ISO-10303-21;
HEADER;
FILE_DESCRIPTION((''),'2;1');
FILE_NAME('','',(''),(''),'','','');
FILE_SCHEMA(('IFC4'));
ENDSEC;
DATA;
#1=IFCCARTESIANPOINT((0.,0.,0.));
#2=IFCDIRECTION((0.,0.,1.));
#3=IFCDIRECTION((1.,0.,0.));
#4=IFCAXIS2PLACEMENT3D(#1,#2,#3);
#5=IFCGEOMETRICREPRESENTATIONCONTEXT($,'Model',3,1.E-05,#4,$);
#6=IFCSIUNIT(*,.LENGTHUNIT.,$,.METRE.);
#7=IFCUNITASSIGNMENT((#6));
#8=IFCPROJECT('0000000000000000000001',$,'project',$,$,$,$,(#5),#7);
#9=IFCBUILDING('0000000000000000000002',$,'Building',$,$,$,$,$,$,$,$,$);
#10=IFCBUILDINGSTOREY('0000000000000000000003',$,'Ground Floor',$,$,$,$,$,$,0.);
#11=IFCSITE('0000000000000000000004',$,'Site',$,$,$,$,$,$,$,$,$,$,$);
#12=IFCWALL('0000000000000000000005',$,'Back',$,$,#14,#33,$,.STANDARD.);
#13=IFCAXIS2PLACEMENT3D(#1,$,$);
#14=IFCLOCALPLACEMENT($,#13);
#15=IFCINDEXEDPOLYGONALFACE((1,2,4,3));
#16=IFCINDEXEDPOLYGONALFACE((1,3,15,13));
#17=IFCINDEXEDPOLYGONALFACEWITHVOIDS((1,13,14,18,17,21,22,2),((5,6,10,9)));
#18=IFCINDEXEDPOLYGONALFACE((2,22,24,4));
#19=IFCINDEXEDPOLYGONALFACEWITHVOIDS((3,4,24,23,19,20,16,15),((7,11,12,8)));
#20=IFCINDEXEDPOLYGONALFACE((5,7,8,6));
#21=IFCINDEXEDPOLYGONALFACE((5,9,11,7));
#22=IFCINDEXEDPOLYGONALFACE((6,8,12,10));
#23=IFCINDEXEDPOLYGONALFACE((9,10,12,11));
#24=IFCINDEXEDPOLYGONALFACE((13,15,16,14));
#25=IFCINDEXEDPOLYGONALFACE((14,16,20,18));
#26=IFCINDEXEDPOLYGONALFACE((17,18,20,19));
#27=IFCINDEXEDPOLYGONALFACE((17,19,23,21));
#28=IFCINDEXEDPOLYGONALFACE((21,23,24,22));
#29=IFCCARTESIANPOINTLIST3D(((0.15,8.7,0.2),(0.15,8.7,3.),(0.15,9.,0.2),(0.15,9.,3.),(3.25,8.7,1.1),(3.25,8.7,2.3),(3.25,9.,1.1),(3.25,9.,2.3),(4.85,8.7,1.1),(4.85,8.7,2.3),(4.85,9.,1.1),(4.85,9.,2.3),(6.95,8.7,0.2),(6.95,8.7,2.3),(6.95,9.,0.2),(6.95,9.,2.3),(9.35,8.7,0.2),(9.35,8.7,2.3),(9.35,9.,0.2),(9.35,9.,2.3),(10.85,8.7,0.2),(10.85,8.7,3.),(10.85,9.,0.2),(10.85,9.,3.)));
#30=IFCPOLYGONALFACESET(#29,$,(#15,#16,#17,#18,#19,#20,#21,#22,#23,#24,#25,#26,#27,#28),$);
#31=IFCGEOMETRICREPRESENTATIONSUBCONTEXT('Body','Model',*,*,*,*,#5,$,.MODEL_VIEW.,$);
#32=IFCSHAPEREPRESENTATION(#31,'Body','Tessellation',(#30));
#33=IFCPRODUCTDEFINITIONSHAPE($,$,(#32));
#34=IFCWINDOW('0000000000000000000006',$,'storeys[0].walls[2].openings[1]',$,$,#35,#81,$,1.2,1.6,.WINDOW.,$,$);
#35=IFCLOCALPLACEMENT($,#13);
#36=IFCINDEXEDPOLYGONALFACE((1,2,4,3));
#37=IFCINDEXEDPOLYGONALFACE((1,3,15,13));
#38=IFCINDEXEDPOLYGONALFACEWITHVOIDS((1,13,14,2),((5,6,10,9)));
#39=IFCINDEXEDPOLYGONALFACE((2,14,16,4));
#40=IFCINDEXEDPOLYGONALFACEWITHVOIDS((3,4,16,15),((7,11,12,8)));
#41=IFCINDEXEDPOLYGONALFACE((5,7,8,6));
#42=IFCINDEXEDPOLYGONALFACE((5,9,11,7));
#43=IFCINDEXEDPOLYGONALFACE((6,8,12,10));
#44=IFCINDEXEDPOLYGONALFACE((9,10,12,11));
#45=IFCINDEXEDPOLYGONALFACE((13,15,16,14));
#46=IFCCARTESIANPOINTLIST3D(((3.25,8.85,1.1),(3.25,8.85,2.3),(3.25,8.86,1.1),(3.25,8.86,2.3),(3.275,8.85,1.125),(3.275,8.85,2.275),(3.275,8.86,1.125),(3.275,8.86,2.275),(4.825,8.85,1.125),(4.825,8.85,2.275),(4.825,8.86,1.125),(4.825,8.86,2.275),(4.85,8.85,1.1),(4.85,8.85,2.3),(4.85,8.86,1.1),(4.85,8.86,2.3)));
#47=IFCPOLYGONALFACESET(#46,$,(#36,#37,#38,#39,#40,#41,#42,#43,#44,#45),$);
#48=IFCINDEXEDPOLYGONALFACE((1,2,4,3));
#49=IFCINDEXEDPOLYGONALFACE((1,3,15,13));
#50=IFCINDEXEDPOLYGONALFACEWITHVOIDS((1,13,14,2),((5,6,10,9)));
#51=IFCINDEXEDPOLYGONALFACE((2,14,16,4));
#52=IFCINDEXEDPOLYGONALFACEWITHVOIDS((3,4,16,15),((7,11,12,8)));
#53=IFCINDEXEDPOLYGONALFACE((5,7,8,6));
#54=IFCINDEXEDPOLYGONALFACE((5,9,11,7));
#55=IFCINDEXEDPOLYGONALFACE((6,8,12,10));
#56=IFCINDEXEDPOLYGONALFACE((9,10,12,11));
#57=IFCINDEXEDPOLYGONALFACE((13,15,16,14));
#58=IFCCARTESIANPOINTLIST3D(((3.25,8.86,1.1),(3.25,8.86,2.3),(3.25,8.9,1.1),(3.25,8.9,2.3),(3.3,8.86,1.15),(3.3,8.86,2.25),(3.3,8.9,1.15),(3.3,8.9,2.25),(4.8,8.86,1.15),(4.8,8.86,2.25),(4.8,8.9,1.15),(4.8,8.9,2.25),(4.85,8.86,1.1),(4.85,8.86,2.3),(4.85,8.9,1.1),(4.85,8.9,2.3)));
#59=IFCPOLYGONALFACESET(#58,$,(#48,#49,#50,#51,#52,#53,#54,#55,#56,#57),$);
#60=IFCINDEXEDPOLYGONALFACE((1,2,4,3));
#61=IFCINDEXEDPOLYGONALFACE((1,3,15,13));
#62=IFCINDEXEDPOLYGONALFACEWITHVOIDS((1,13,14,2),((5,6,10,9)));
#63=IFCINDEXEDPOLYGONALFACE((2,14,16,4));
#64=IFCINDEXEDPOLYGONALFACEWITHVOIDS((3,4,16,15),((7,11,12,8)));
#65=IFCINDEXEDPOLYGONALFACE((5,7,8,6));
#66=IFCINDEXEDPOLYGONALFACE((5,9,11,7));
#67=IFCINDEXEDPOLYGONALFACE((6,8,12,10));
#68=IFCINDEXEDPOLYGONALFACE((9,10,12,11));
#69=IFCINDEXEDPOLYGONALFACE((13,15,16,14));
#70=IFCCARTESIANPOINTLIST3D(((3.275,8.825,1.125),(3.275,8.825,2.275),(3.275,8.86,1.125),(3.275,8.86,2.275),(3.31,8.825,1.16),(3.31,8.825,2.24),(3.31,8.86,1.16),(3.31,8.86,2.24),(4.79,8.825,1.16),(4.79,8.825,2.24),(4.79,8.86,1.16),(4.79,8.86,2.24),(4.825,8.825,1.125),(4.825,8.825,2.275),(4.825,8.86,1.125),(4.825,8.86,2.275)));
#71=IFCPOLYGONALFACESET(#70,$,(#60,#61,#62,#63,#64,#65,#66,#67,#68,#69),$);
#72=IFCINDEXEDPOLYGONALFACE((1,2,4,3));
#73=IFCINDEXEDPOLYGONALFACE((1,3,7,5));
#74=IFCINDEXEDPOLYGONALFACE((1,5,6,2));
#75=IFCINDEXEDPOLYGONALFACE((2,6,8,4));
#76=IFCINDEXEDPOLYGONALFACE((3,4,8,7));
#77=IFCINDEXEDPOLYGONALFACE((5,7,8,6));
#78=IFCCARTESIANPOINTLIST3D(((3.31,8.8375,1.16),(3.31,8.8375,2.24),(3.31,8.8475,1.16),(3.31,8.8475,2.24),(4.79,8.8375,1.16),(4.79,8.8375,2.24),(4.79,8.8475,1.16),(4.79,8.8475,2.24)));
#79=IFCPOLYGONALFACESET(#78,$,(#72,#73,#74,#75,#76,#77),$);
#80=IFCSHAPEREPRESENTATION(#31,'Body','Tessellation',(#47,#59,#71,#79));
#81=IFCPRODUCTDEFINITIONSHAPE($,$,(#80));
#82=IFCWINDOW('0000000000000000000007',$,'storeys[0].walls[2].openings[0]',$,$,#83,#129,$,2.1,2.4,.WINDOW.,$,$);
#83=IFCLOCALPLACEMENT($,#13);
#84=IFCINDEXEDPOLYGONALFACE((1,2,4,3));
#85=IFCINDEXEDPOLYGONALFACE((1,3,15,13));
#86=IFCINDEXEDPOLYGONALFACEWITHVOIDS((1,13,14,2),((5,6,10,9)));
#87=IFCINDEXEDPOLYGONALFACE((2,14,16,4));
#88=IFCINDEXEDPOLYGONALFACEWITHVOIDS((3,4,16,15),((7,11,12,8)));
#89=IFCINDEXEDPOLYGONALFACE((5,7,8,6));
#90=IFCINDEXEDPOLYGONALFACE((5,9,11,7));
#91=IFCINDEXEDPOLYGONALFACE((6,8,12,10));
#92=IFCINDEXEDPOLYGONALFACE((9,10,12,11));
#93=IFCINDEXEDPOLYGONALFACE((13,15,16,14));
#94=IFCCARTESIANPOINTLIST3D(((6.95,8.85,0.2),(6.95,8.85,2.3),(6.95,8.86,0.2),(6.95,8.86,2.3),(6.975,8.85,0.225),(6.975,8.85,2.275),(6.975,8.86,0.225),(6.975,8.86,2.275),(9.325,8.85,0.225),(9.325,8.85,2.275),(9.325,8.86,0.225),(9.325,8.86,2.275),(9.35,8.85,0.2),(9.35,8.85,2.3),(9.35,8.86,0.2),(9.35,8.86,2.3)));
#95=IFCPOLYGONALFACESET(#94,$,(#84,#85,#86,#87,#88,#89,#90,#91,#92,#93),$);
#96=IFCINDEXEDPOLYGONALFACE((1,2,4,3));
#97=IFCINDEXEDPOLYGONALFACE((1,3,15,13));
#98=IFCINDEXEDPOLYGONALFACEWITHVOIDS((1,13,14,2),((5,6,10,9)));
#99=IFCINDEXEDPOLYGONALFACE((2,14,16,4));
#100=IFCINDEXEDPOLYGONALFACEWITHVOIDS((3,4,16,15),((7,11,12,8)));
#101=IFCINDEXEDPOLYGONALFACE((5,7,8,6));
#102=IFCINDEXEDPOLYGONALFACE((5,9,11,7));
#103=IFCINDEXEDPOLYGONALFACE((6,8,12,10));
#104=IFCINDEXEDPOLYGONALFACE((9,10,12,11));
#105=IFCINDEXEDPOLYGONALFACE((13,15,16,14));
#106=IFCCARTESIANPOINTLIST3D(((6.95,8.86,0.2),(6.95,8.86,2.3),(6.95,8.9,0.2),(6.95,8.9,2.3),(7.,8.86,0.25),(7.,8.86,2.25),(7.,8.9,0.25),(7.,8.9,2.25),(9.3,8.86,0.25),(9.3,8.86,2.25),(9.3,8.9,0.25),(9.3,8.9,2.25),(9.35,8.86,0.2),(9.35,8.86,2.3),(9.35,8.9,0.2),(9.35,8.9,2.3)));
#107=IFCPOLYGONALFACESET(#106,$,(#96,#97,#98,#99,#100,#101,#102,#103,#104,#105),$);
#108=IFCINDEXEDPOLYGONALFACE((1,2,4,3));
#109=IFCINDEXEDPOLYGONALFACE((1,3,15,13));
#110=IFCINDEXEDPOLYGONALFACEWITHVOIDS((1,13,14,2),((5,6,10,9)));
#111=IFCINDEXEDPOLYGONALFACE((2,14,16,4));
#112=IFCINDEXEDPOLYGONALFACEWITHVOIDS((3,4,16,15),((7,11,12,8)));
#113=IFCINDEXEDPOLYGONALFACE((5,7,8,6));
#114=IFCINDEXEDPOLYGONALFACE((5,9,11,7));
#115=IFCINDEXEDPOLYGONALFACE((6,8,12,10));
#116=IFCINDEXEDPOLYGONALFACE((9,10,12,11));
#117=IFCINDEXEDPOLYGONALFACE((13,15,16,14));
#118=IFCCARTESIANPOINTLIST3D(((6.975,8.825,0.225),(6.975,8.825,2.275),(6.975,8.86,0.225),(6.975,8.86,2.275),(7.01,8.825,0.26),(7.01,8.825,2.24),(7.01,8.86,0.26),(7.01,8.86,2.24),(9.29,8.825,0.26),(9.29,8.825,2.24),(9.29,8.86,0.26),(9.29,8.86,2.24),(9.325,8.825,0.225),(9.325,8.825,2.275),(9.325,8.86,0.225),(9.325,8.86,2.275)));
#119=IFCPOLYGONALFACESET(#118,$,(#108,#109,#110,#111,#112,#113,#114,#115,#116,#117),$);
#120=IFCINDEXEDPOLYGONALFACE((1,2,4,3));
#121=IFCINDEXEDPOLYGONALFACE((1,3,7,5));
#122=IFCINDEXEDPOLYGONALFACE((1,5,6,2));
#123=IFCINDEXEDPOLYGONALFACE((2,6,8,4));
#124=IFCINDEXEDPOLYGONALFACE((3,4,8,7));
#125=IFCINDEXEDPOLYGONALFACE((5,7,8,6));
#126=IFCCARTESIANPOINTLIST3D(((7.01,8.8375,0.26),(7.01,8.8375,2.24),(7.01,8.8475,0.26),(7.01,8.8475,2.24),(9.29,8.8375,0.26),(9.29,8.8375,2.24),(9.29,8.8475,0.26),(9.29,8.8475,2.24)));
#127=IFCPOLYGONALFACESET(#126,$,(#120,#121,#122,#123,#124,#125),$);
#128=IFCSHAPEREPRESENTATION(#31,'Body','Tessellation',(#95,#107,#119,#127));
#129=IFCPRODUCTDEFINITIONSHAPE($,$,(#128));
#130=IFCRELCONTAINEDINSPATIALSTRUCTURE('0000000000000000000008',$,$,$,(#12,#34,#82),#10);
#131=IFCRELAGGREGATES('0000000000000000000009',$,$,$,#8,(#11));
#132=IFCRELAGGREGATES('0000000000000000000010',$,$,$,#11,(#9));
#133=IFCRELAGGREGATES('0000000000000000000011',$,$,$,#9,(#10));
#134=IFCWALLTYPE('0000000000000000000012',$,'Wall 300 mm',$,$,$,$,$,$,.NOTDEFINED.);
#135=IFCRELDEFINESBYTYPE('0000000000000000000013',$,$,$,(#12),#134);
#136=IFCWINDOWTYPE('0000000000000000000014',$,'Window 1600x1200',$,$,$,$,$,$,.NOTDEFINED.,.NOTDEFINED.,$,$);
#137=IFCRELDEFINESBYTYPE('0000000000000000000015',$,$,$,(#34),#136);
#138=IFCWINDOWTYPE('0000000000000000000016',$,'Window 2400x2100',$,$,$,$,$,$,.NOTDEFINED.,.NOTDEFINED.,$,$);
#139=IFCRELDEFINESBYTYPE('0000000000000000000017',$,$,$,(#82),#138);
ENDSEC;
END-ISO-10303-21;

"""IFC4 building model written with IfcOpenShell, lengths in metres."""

from ifc_helpers import new_model, si_unit, frame, origin_with_axes, place, context, subcontext, project, spatial, line, indexed_curve, outline, extrude, type_object, element, fill, save


model = new_model("IFC4")

# Units and contexts
model_context = context("Model", 3, precision=1e-05, world=origin_with_axes())
body_context = subcontext(model_context, "Body", "Model", "MODEL_VIEW")
ifc_project = project(units=[si_unit("LENGTHUNIT", "METRE")], contexts=[model_context])

# Site, building, storey
site = spatial("IfcSite", under=ifc_project, Name="Site")
building = spatial("IfcBuilding", under=site, Name="Building")
storey = spatial("IfcBuildingStorey", under=building, Name="Ground Floor", Elevation=0.0)

# Shared definitions
wall_type_1 = type_object("IfcWallType", Name="Wall 300 mm", PredefinedType="NOTDEFINED")
window_type_1 = type_object("IfcWindowType", Name="Window 1600x1200", PartitioningType="NOTDEFINED", PredefinedType="NOTDEFINED")

# Wall, openings, windows
wall_1_placement = place(None, frame((10.85, 8.85, 0.2), z_axis=(0.0, 0.0, 1.0), x_axis=(-1.0, 0.0, 0.0)))
wall_1 = element("IfcWall", 1, at=wall_1_placement, inside=storey, type_object=wall_type_1, Name="Back", PredefinedType="STANDARD", context=body_context, shape_type="SweptSolid", body=[
    extrude(outline(indexed_curve([(0.0, 0.0), (0.0, 0.3), (10.7, 0.3), (10.7, 0.0), (0.0, 0.0)], self_intersect=False)), frame((0.0, -0.15, 0.0), z_axis=(0.0, 0.0, 1.0), x_axis=(1.0, 0.0, 0.0)), (0.0, 0.0, 1.0), 2.8),
])
opening_1_placement = place(wall_1_placement, frame((1.5, -0.16, 0.0), z_axis=(0.0, 0.0, 1.0), x_axis=(1.0, 0.0, 0.0)))
opening_1 = element("IfcOpeningElement", 2, at=opening_1_placement, cuts=wall_1, context=body_context, shape_type="SweptSolid", body=[
    extrude(outline(indexed_curve([(0.0, 0.0), (0.0, 0.32), (2.4, 0.32), (2.4, 0.0), (0.0, 0.0)], self_intersect=False)), origin_with_axes(), (0.0, 0.0, 1.0), 2.1),
])
opening_2_placement = place(wall_1_placement, frame((6.0, -0.16, 0.9), z_axis=(0.0, 0.0, 1.0), x_axis=(1.0, 0.0, 0.0)))
opening_2 = element("IfcOpeningElement", 3, at=opening_2_placement, cuts=wall_1, context=body_context, shape_type="SweptSolid", body=[
    extrude(outline(indexed_curve([(0.0, 0.0), (0.0, 0.32), (1.6, 0.32), (1.6, 0.0), (0.0, 0.0)], self_intersect=False)), origin_with_axes(), (0.0, 0.0, 1.0), 1.2),
])
window_1_placement = place(None, frame((4.85, 8.95, 1.1), z_axis=(0.0, 0.0, 1.0), x_axis=(-1.0, 0.0, 0.0)))
window_1 = element("IfcWindow", 4, at=window_1_placement, inside=storey, type_object=window_type_1, Name="storeys[0].walls[2].openings[1]", OverallHeight=1.2, OverallWidth=1.6, PredefinedType="WINDOW", context=body_context, shape_type="SweptSolid", body=[
    extrude(outline(indexed_curve([(0.0, 0.0), (1.6, 0.0), (1.6, 1.2), (0.0, 1.2)], segments=[line(1, 2, 3, 4, 1)]), holes=[indexed_curve([(0.025, 0.025), (1.575, 0.025), (1.575, 1.175), (0.025, 1.175)], segments=[line(1, 2, 3, 4, 1)])]), frame((0.0, 0.09, 0.0), z_axis=(0.0, -1.0, 0.0), x_axis=(1.0, 0.0, 0.0)), (0.0, 0.0, -1.0), 0.01),
    extrude(outline(indexed_curve([(0.0, 0.0), (1.6, 0.0), (1.6, 1.2), (0.0, 1.2)], segments=[line(1, 2, 3, 4, 1)]), holes=[indexed_curve([(0.05, 0.05), (1.55, 0.05), (1.55, 1.15), (0.05, 1.15)], segments=[line(1, 2, 3, 4, 1)])]), frame((0.0, 0.05, 0.0), z_axis=(0.0, -1.0, 0.0), x_axis=(1.0, 0.0, 0.0)), (0.0, 0.0, -1.0), 0.04),
    extrude(outline(indexed_curve([(0.0, 0.0), (1.55, 0.0), (1.55, 1.15), (0.0, 1.15)], segments=[line(1, 2, 3, 4, 1)]), holes=[indexed_curve([(0.035, 0.035), (1.515, 0.035), (1.515, 1.115), (0.035, 1.115)], segments=[line(1, 2, 3, 4, 1)])]), frame((0.025, 0.09, 0.025), z_axis=(0.0, -1.0, 0.0), x_axis=(1.0, 0.0, 0.0)), (0.0, 0.0, -1.0), 0.035),
    extrude(outline(indexed_curve([(0.035, 0.035), (1.515, 0.035), (1.515, 1.115), (0.035, 1.115)], segments=[line(1, 2, 3, 4, 1)])), frame((0.025, 0.1025, 0.025), z_axis=(0.0, -1.0, 0.0), x_axis=(1.0, 0.0, 0.0)), (0.0, 0.0, -1.0), 0.01),
])
fill(opening_2, window_1)
window_type_2 = type_object("IfcWindowType", Name="Window 2400x2100", PartitioningType="NOTDEFINED", PredefinedType="NOTDEFINED")
window_2_placement = place(None, frame((9.35, 8.95, 0.2), z_axis=(0.0, 0.0, 1.0), x_axis=(-1.0, 0.0, 0.0)))
window_2 = element("IfcWindow", 5, at=window_2_placement, inside=storey, type_object=window_type_2, Name="storeys[0].walls[2].openings[0]", OverallHeight=2.1, OverallWidth=2.4, PredefinedType="WINDOW", context=body_context, shape_type="SweptSolid", body=[
    extrude(outline(indexed_curve([(0.0, 0.0), (2.4, 0.0), (2.4, 2.1), (0.0, 2.1)], segments=[line(1, 2, 3, 4, 1)]), holes=[indexed_curve([(0.025, 0.025), (2.375, 0.025), (2.375, 2.075), (0.025, 2.075)], segments=[line(1, 2, 3, 4, 1)])]), frame((0.0, 0.09, 0.0), z_axis=(0.0, -1.0, 0.0), x_axis=(1.0, 0.0, 0.0)), (0.0, 0.0, -1.0), 0.01),
    extrude(outline(indexed_curve([(0.0, 0.0), (2.4, 0.0), (2.4, 2.1), (0.0, 2.1)], segments=[line(1, 2, 3, 4, 1)]), holes=[indexed_curve([(0.05, 0.05), (2.35, 0.05), (2.35, 2.05), (0.05, 2.05)], segments=[line(1, 2, 3, 4, 1)])]), frame((0.0, 0.05, 0.0), z_axis=(0.0, -1.0, 0.0), x_axis=(1.0, 0.0, 0.0)), (0.0, 0.0, -1.0), 0.04),
    extrude(outline(indexed_curve([(0.0, 0.0), (2.35, 0.0), (2.35, 2.05), (0.0, 2.05)], segments=[line(1, 2, 3, 4, 1)]), holes=[indexed_curve([(0.035, 0.035), (2.315, 0.035), (2.315, 2.015), (0.035, 2.015)], segments=[line(1, 2, 3, 4, 1)])]), frame((0.025, 0.09, 0.025), z_axis=(0.0, -1.0, 0.0), x_axis=(1.0, 0.0, 0.0)), (0.0, 0.0, -1.0), 0.035),
    extrude(outline(indexed_curve([(0.035, 0.035), (2.315, 0.035), (2.315, 2.015), (0.035, 2.015)], segments=[line(1, 2, 3, 4, 1)])), frame((0.025, 0.1025, 0.025), z_axis=(0.0, -1.0, 0.0), x_axis=(1.0, 0.0, 0.0)), (0.0, 0.0, -1.0), 0.01),
])
fill(opening_1, window_2)

save(model, "model.ifc")
